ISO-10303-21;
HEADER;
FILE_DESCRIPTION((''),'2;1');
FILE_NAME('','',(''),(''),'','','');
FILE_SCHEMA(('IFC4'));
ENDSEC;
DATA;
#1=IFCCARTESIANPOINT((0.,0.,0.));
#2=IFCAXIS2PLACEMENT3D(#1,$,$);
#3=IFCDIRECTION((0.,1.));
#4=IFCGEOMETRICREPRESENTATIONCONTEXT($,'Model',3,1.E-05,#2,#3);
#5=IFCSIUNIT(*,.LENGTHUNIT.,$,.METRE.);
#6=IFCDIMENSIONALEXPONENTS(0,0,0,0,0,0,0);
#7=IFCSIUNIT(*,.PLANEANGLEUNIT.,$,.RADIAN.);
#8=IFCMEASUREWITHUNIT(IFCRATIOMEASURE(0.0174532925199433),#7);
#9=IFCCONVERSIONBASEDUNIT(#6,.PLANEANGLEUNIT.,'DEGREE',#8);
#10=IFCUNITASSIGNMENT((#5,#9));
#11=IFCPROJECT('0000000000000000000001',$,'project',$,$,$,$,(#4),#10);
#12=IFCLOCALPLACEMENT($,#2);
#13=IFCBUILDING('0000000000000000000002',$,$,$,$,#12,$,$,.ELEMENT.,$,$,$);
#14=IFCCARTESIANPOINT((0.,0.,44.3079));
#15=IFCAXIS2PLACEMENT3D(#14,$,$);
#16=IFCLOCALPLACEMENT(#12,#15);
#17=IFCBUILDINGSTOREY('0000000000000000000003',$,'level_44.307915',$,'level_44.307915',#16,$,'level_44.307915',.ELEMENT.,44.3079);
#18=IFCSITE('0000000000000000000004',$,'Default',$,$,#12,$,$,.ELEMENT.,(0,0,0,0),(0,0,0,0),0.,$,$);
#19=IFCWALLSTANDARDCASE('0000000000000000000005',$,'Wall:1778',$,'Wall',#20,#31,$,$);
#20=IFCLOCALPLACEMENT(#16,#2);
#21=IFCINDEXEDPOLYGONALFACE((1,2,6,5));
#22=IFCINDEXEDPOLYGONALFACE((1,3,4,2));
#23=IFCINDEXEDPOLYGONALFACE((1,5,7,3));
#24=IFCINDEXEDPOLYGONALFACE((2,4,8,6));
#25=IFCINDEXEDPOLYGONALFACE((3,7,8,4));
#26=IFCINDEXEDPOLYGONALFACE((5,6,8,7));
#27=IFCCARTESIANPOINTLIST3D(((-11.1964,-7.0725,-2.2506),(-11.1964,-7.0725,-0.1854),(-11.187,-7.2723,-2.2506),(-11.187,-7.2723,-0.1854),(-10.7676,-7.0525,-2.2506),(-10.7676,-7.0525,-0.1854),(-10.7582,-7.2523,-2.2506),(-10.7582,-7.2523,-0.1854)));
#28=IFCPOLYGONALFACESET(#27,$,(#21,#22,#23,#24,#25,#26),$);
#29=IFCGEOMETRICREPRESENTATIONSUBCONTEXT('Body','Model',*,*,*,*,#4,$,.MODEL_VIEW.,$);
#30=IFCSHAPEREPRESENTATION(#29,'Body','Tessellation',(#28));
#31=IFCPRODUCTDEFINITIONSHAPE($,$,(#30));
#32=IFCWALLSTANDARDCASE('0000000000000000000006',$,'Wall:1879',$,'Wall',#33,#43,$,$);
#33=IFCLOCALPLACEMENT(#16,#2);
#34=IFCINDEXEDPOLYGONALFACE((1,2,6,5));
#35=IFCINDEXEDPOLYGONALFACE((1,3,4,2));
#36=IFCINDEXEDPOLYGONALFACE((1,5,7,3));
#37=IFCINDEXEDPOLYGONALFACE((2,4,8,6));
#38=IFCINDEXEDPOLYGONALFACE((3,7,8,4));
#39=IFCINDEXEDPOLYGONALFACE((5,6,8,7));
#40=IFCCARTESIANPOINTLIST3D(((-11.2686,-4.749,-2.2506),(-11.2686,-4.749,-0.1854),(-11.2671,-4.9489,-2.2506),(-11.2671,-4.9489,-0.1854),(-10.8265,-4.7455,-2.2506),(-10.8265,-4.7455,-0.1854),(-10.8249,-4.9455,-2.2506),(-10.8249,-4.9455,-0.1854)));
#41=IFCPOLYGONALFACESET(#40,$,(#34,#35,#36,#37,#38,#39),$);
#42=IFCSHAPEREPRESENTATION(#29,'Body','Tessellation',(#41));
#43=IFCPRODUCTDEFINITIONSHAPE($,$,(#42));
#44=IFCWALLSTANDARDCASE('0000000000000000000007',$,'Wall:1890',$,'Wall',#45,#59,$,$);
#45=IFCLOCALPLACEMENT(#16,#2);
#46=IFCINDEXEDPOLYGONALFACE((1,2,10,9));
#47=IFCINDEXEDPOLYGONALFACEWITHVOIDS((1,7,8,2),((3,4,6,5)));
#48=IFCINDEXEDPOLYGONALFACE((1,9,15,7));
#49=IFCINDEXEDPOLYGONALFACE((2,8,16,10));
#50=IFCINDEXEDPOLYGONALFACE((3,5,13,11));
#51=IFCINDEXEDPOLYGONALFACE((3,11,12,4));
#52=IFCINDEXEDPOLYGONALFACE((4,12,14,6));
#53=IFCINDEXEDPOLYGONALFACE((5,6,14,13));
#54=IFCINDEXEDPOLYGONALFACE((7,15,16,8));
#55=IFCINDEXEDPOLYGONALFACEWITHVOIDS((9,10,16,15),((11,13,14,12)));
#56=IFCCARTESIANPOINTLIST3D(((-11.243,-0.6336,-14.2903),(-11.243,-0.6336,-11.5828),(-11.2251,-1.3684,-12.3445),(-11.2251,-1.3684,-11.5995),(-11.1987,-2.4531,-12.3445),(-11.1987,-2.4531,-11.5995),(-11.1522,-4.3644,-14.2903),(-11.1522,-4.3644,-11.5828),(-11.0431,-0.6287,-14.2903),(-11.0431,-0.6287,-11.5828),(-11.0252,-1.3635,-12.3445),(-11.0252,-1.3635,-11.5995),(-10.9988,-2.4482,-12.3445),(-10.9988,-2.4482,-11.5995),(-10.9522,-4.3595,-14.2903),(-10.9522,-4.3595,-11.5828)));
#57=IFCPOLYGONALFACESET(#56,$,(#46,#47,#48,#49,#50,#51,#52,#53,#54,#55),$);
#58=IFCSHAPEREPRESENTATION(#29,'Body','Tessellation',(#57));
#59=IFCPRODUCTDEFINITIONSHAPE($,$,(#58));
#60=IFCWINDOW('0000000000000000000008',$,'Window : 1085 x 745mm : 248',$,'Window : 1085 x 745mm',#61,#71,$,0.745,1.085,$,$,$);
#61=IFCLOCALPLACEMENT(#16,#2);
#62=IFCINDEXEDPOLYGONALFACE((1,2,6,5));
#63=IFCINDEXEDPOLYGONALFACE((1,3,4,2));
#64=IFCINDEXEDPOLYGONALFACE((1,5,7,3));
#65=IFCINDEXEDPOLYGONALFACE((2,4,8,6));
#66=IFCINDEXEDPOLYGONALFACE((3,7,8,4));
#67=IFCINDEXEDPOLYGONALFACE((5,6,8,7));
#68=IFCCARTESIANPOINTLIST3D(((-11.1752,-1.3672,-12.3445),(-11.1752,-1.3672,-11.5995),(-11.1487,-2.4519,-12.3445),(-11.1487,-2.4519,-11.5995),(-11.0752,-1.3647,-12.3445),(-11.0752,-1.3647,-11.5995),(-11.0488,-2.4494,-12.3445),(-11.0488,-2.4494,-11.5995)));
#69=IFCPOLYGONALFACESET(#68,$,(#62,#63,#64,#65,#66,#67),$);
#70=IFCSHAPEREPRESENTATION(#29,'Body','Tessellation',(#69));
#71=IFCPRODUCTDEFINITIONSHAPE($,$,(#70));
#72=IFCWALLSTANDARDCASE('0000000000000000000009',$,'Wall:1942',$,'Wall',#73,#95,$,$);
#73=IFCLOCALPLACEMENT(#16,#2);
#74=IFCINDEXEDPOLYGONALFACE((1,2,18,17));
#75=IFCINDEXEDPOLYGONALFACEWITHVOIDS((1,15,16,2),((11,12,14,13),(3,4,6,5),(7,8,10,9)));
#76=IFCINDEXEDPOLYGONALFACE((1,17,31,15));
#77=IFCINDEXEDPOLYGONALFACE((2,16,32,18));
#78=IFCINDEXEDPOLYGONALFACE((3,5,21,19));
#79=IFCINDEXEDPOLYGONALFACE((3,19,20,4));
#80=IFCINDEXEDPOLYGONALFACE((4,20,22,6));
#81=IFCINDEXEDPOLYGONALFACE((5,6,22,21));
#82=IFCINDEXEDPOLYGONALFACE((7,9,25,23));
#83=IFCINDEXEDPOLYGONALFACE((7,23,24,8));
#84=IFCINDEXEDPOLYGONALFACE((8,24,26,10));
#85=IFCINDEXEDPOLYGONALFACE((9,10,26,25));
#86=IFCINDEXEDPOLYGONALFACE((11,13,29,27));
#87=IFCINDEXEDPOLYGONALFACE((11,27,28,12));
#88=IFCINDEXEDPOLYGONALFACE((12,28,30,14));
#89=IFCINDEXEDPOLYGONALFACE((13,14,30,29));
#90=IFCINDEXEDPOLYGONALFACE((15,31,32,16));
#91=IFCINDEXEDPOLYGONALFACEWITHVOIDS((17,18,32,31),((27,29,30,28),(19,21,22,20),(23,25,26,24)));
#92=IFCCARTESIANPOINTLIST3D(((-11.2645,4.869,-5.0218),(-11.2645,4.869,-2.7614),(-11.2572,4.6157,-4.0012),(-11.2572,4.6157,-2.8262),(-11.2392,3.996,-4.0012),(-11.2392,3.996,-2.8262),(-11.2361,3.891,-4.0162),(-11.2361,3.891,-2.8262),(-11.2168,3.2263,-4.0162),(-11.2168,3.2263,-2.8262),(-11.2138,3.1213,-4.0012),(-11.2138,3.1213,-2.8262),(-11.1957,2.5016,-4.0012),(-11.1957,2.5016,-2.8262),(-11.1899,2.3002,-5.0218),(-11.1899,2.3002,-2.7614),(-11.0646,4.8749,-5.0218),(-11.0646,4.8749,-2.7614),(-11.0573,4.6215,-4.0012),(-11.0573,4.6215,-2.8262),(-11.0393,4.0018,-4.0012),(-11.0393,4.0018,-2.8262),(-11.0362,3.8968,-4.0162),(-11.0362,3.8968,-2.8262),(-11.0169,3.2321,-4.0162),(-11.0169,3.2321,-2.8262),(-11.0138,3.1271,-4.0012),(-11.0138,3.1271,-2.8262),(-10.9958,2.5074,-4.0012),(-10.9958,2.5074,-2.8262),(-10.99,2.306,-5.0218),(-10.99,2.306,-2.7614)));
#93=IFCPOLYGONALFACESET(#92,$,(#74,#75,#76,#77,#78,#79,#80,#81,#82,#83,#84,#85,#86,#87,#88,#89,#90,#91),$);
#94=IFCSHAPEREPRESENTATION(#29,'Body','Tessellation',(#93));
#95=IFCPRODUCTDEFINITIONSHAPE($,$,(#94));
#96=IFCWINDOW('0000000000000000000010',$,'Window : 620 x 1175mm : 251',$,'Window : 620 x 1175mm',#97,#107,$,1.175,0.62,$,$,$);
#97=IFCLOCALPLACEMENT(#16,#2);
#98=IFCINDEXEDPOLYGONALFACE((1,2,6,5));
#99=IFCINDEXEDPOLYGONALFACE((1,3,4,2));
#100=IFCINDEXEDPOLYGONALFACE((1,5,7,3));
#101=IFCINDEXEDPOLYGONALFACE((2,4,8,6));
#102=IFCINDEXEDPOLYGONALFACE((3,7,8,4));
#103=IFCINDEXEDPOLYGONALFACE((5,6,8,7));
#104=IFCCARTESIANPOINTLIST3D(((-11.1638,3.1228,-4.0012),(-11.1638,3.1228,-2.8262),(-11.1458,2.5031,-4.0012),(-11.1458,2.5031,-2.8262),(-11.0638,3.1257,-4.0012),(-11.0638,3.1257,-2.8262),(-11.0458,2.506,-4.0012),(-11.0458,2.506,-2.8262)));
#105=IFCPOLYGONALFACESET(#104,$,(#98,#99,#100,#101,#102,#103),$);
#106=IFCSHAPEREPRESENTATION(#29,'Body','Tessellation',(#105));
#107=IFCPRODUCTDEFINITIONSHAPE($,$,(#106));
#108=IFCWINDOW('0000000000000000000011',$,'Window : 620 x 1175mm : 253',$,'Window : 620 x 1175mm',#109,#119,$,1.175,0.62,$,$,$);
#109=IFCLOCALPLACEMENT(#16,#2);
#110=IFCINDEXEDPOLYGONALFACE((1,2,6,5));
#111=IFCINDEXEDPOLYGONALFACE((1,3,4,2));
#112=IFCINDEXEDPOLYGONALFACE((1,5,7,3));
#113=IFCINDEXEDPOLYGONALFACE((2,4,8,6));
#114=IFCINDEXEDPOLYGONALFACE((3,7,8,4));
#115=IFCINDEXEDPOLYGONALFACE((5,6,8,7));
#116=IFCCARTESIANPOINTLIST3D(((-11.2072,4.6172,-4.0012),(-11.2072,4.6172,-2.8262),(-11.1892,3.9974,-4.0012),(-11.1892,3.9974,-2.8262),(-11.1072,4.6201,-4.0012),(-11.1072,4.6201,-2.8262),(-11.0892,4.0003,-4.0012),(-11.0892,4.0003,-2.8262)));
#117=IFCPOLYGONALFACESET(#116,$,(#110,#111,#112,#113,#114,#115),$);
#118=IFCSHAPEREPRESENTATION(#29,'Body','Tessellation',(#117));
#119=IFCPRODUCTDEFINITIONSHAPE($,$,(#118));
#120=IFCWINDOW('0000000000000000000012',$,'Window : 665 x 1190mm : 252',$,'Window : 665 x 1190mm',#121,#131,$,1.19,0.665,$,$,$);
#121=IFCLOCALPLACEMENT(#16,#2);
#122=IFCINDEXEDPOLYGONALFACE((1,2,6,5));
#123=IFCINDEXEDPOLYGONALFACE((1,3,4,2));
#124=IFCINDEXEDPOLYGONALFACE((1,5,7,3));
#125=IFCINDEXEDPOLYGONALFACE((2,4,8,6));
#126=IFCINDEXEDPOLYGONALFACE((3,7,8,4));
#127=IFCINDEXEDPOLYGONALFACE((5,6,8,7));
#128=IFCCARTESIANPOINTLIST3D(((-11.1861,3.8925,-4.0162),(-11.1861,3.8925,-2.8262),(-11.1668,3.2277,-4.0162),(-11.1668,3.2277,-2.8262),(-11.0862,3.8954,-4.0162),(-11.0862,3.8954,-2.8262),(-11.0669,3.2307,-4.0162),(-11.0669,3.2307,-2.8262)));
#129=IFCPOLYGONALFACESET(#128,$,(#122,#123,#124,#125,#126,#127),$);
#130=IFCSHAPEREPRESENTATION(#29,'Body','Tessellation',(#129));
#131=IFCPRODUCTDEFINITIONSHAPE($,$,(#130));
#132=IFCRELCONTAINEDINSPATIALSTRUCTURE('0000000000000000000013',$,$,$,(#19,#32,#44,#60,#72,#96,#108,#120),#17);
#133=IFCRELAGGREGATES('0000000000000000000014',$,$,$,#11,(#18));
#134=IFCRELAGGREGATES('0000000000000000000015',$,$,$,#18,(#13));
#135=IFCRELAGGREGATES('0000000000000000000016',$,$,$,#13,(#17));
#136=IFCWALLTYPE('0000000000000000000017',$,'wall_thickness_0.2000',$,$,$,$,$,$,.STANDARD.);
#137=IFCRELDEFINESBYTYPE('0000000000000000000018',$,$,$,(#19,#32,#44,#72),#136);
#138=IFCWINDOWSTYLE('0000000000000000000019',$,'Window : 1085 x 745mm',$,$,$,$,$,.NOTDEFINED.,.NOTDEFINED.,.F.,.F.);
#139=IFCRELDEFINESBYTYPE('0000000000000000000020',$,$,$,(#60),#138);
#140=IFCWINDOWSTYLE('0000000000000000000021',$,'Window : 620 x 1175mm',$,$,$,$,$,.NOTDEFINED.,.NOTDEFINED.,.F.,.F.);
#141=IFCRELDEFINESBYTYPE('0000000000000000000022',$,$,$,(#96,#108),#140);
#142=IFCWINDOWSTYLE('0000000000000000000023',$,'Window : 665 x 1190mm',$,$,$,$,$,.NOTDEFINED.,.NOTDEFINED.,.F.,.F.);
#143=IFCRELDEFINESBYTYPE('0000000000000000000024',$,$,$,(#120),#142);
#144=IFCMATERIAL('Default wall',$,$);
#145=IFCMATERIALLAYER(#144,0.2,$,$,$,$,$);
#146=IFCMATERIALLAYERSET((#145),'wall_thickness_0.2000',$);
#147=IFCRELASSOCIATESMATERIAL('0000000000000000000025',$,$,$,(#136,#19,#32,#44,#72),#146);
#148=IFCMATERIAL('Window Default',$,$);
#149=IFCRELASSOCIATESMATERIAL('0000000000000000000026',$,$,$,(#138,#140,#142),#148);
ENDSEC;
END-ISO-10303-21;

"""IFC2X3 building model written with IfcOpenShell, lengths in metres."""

from ifc_helpers import new_model, entity, si_unit, converted_unit, direction, frame, frame_2d, origin, origin_2d_with_axis, place, context, subcontext, project, spatial, polyline, rectangle, outline, extrude, source, transform, mapped, material, layer, layer_set, layer_usage, type_object, type_shapes, element, fill, save


model = new_model("IFC2X3")

# Units and contexts
model_context = context("Model", 3, precision=1e-05, world=origin(), true_north=direction((0.0, 1.0)))
body_context = subcontext(model_context, "Body", "Model", "MODEL_VIEW")
ifc_project = project(units=[si_unit("LENGTHUNIT", "METRE"), converted_unit("PLANEANGLEUNIT", "DEGREE", entity("IfcRatioMeasure", 0.0174532925199433), si_unit("PLANEANGLEUNIT", "RADIAN"), dimensions=[0, 0, 0, 0, 0, 0, 0])], contexts=[model_context])

# Site, building, storey
placement_1 = place(None, origin())
site = spatial("IfcSite", under=ifc_project, at=placement_1, Name="Default", CompositionType="ELEMENT", RefLatitude=(0, 0, 0, 0), RefLongitude=(0, 0, 0, 0), RefElevation=0.0)
building = spatial("IfcBuilding", under=site, at=placement_1, CompositionType="ELEMENT")
storey_placement = place(placement_1, frame((0.0, 0.0, 44.3079)))
storey = spatial("IfcBuildingStorey", under=building, at=storey_placement, Name="level_44.307915", ObjectType="level_44.307915", LongName="level_44.307915", CompositionType="ELEMENT", Elevation=44.3079)

# Walls
ifc_material_1 = material(Name="Default wall")
ifc_layer = layer(ifc_material_1, 0.2)
ifc_layer_set = layer_set([ifc_layer], Name="wall_thickness_0.2000")
ifc_layer_usage = layer_usage(ifc_layer_set, "AXIS2", "POSITIVE", -0.1)
wall_type = type_object("IfcWallType", Name="wall_thickness_0.2000", PredefinedType="STANDARD", material=ifc_layer_set)
placement_2 = place(placement_1, frame((0.0, 0.0, 42.0573)))
wall_1_placement = place(placement_2, frame((-10.7629, -7.1524, 0.0), z_axis=(0.0, 0.0, 1.0), x_axis=(-0.998908, -0.046712, 0.0)))
element("IfcWallStandardCase", 1, at=wall_1_placement, inside=storey, type_object=wall_type, material=ifc_layer_usage, Name="Wall:1778", ObjectType="Wall", context=body_context, shape_type="SweptSolid", body=[
    extrude(outline(polyline([(0.4292, -0.1), (0.4292, 0.1), (0.0, 0.1), (0.0, -0.1), (0.4292, -0.1)])), origin(), (0.0, 0.0, 1.0), 2.0652),
])
placement_3 = place(placement_1, frame((0.0, 0.0, 42.0573)))
wall_2_placement = place(placement_3, frame((-10.8257, -4.8455, 0.0), z_axis=(0.0, 0.0, 1.0), x_axis=(-0.99997, -0.00778, 0.0)))
element("IfcWallStandardCase", 2, at=wall_2_placement, inside=storey, type_object=wall_type, material=ifc_layer_usage, Name="Wall:1879", ObjectType="Wall", context=body_context, shape_type="SweptSolid", body=[
    extrude(outline(polyline([(0.4422, -0.1), (0.4422, 0.1), (0.0, 0.1), (0.0, -0.1), (0.4422, -0.1)])), origin(), (0.0, 0.0, 1.0), 2.0652),
])

# Wall, opening, window
placement_4 = place(placement_1, frame((0.0, 0.0, 30.0176)))
wall_3_placement = place(placement_4, frame((-11.0522, -4.362, 0.0), z_axis=(0.0, 0.0, 1.0), x_axis=(-0.024351, 0.999703, 0.0)))
wall_3 = element("IfcWallStandardCase", 3, at=wall_3_placement, inside=storey, type_object=wall_type, material=ifc_layer_usage, Name="Wall:1890", ObjectType="Wall", context=body_context, shape_type="SweptSolid", body=[
    extrude(outline(polyline([(3.7319, -0.1), (3.7319, 0.1), (0.0, 0.1), (0.0, -0.1), (3.7319, -0.1)])), origin(), (0.0, 0.0, 1.0), 2.7075),
])
opening_1_placement = place(wall_3_placement, frame((1.9119, -0.1, 1.9458)))
opening_1 = element("IfcOpeningElement", 4, at=opening_1_placement, cuts=wall_3, ObjectType="Opening", context=body_context, shape_type="SweptSolid", body=[
    extrude(rectangle(XDim=1.085, YDim=0.745, at=frame_2d((0.3725, 0.5425), x_axis=(0.0, 1.0))), frame((0.0, 0.0, 0.0), z_axis=(0.0, 1.0, 0.0), x_axis=(0.0, 0.0, 1.0)), (0.0, 0.0, 1.0), 0.2),
])
ifc_material_2 = material(Name="Window Default")
window_style_1 = type_object("IfcWindowStyle", Name="Window : 1085 x 745mm", ConstructionType="NOTDEFINED", OperationType="NOTDEFINED", ParameterTakesPrecedence=False, Sizeable=False, material=ifc_material_2)
shared_shape_1 = source(origin(), body_context, "Body", "SweptSolid", [
    extrude(rectangle(XDim=0.1, YDim=1.085, at=origin_2d_with_axis()), frame((0.5425, 0.1, 0.0), z_axis=(0.0, 0.0, 1.0), x_axis=(0.0, 1.0, 0.0)), (0.0, 0.0, 1.0), 0.745),
])
type_shapes(window_style_1, [shared_shape_1])
window_1_placement = place(opening_1_placement, origin())
window_1 = element("IfcWindow", 5, at=window_1_placement, inside=storey, type_object=window_style_1, Name="Window : 1085 x 745mm : 248", ObjectType="Window : 1085 x 745mm", OverallHeight=0.745, OverallWidth=1.085, context=body_context, shape_type="MappedRepresentation", body=[
    mapped(shared_shape_1, transform((0.0, 0.0, 0.0), scale=1.0)),
])
fill(opening_1, window_1)

# Wall, openings, windows
placement_5 = place(placement_1, frame((0.0, 0.0, 39.2861)))
wall_4_placement = place(placement_5, frame((-11.0899, 2.3031, 0.0), z_axis=(0.0, 0.0, 1.0), x_axis=(-0.029051, 0.999578, 0.0)))
wall_4 = element("IfcWallStandardCase", 6, at=wall_4_placement, inside=storey, type_object=wall_type, material=ifc_layer_usage, Name="Wall:1942", ObjectType="Wall", context=body_context, shape_type="SweptSolid", body=[
    extrude(outline(polyline([(2.5699, -0.1), (2.5699, 0.1), (0.0, 0.1), (0.0, -0.1), (2.5699, -0.1)])), origin(), (0.0, 0.0, 1.0), 2.2604),
])
opening_2_placement = place(wall_4_placement, frame((0.2014, -0.1, 1.0206)))
opening_2 = element("IfcOpeningElement", 7, at=opening_2_placement, cuts=wall_4, ObjectType="Opening", context=body_context, shape_type="SweptSolid", body=[
    extrude(rectangle(XDim=0.62, YDim=1.175, at=frame_2d((0.5875, 0.31), x_axis=(0.0, 1.0))), frame((0.0, 0.0, 0.0), z_axis=(0.0, 1.0, 0.0), x_axis=(0.0, 0.0, 1.0)), (0.0, 0.0, 1.0), 0.2),
])
opening_3_placement = place(wall_4_placement, frame((0.9264, -0.1, 1.0056)))
opening_3 = element("IfcOpeningElement", 8, at=opening_3_placement, cuts=wall_4, ObjectType="Opening", context=body_context, shape_type="SweptSolid", body=[
    extrude(rectangle(XDim=0.665, YDim=1.19, at=frame_2d((0.595, 0.3325), x_axis=(0.0, 1.0))), frame((0.0, 0.0, 0.0), z_axis=(0.0, 1.0, 0.0), x_axis=(0.0, 0.0, 1.0)), (0.0, 0.0, 1.0), 0.2),
])
opening_4_placement = place(wall_4_placement, frame((1.6964, -0.1, 1.0206)))
opening_4 = element("IfcOpeningElement", 9, at=opening_4_placement, cuts=wall_4, ObjectType="Opening", context=body_context, shape_type="SweptSolid", body=[
    extrude(rectangle(XDim=0.62, YDim=1.175, at=frame_2d((0.5875, 0.31), x_axis=(0.0, 1.0))), frame((0.0, 0.0, 0.0), z_axis=(0.0, 1.0, 0.0), x_axis=(0.0, 0.0, 1.0)), (0.0, 0.0, 1.0), 0.2),
])
window_style_2 = type_object("IfcWindowStyle", Name="Window : 620 x 1175mm", ConstructionType="NOTDEFINED", OperationType="NOTDEFINED", ParameterTakesPrecedence=False, Sizeable=False, material=ifc_material_2)
shared_shape_2 = source(origin(), body_context, "Body", "SweptSolid", [
    extrude(rectangle(XDim=0.1, YDim=0.62, at=origin_2d_with_axis()), frame((0.31, 0.1, 0.0), z_axis=(0.0, 0.0, 1.0), x_axis=(0.0, 1.0, 0.0)), (0.0, 0.0, 1.0), 1.175),
])
type_shapes(window_style_2, [shared_shape_2])
window_2_placement = place(opening_2_placement, origin())
window_2 = element("IfcWindow", 10, at=window_2_placement, inside=storey, type_object=window_style_2, Name="Window : 620 x 1175mm : 251", ObjectType="Window : 620 x 1175mm", OverallHeight=1.175, OverallWidth=0.62, context=body_context, shape_type="MappedRepresentation", body=[
    mapped(shared_shape_2, transform((0.0, 0.0, 0.0), scale=1.0)),
])
fill(opening_2, window_2)
window_3_placement = place(opening_4_placement, origin())
window_3 = element("IfcWindow", 11, at=window_3_placement, inside=storey, type_object=window_style_2, Name="Window : 620 x 1175mm : 253", ObjectType="Window : 620 x 1175mm", OverallHeight=1.175, OverallWidth=0.62, context=body_context, shape_type="MappedRepresentation", body=[
    mapped(shared_shape_2, transform((0.0, 0.0, 0.0), scale=1.0)),
])
fill(opening_4, window_3)
window_style_3 = type_object("IfcWindowStyle", Name="Window : 665 x 1190mm", ConstructionType="NOTDEFINED", OperationType="NOTDEFINED", ParameterTakesPrecedence=False, Sizeable=False, material=ifc_material_2)
shared_shape_3 = source(origin(), body_context, "Body", "SweptSolid", [
    extrude(rectangle(XDim=0.1, YDim=0.665, at=origin_2d_with_axis()), frame((0.3325, 0.1, 0.0), z_axis=(0.0, 0.0, 1.0), x_axis=(0.0, 1.0, 0.0)), (0.0, 0.0, 1.0), 1.19),
])
type_shapes(window_style_3, [shared_shape_3])
window_4_placement = place(opening_3_placement, origin())
window_4 = element("IfcWindow", 12, at=window_4_placement, inside=storey, type_object=window_style_3, Name="Window : 665 x 1190mm : 252", ObjectType="Window : 665 x 1190mm", OverallHeight=1.19, OverallWidth=0.665, context=body_context, shape_type="MappedRepresentation", body=[
    mapped(shared_shape_3, transform((0.0, 0.0, 0.0), scale=1.0)),
])
fill(opening_3, window_4)

save(model, "model.ifc")
